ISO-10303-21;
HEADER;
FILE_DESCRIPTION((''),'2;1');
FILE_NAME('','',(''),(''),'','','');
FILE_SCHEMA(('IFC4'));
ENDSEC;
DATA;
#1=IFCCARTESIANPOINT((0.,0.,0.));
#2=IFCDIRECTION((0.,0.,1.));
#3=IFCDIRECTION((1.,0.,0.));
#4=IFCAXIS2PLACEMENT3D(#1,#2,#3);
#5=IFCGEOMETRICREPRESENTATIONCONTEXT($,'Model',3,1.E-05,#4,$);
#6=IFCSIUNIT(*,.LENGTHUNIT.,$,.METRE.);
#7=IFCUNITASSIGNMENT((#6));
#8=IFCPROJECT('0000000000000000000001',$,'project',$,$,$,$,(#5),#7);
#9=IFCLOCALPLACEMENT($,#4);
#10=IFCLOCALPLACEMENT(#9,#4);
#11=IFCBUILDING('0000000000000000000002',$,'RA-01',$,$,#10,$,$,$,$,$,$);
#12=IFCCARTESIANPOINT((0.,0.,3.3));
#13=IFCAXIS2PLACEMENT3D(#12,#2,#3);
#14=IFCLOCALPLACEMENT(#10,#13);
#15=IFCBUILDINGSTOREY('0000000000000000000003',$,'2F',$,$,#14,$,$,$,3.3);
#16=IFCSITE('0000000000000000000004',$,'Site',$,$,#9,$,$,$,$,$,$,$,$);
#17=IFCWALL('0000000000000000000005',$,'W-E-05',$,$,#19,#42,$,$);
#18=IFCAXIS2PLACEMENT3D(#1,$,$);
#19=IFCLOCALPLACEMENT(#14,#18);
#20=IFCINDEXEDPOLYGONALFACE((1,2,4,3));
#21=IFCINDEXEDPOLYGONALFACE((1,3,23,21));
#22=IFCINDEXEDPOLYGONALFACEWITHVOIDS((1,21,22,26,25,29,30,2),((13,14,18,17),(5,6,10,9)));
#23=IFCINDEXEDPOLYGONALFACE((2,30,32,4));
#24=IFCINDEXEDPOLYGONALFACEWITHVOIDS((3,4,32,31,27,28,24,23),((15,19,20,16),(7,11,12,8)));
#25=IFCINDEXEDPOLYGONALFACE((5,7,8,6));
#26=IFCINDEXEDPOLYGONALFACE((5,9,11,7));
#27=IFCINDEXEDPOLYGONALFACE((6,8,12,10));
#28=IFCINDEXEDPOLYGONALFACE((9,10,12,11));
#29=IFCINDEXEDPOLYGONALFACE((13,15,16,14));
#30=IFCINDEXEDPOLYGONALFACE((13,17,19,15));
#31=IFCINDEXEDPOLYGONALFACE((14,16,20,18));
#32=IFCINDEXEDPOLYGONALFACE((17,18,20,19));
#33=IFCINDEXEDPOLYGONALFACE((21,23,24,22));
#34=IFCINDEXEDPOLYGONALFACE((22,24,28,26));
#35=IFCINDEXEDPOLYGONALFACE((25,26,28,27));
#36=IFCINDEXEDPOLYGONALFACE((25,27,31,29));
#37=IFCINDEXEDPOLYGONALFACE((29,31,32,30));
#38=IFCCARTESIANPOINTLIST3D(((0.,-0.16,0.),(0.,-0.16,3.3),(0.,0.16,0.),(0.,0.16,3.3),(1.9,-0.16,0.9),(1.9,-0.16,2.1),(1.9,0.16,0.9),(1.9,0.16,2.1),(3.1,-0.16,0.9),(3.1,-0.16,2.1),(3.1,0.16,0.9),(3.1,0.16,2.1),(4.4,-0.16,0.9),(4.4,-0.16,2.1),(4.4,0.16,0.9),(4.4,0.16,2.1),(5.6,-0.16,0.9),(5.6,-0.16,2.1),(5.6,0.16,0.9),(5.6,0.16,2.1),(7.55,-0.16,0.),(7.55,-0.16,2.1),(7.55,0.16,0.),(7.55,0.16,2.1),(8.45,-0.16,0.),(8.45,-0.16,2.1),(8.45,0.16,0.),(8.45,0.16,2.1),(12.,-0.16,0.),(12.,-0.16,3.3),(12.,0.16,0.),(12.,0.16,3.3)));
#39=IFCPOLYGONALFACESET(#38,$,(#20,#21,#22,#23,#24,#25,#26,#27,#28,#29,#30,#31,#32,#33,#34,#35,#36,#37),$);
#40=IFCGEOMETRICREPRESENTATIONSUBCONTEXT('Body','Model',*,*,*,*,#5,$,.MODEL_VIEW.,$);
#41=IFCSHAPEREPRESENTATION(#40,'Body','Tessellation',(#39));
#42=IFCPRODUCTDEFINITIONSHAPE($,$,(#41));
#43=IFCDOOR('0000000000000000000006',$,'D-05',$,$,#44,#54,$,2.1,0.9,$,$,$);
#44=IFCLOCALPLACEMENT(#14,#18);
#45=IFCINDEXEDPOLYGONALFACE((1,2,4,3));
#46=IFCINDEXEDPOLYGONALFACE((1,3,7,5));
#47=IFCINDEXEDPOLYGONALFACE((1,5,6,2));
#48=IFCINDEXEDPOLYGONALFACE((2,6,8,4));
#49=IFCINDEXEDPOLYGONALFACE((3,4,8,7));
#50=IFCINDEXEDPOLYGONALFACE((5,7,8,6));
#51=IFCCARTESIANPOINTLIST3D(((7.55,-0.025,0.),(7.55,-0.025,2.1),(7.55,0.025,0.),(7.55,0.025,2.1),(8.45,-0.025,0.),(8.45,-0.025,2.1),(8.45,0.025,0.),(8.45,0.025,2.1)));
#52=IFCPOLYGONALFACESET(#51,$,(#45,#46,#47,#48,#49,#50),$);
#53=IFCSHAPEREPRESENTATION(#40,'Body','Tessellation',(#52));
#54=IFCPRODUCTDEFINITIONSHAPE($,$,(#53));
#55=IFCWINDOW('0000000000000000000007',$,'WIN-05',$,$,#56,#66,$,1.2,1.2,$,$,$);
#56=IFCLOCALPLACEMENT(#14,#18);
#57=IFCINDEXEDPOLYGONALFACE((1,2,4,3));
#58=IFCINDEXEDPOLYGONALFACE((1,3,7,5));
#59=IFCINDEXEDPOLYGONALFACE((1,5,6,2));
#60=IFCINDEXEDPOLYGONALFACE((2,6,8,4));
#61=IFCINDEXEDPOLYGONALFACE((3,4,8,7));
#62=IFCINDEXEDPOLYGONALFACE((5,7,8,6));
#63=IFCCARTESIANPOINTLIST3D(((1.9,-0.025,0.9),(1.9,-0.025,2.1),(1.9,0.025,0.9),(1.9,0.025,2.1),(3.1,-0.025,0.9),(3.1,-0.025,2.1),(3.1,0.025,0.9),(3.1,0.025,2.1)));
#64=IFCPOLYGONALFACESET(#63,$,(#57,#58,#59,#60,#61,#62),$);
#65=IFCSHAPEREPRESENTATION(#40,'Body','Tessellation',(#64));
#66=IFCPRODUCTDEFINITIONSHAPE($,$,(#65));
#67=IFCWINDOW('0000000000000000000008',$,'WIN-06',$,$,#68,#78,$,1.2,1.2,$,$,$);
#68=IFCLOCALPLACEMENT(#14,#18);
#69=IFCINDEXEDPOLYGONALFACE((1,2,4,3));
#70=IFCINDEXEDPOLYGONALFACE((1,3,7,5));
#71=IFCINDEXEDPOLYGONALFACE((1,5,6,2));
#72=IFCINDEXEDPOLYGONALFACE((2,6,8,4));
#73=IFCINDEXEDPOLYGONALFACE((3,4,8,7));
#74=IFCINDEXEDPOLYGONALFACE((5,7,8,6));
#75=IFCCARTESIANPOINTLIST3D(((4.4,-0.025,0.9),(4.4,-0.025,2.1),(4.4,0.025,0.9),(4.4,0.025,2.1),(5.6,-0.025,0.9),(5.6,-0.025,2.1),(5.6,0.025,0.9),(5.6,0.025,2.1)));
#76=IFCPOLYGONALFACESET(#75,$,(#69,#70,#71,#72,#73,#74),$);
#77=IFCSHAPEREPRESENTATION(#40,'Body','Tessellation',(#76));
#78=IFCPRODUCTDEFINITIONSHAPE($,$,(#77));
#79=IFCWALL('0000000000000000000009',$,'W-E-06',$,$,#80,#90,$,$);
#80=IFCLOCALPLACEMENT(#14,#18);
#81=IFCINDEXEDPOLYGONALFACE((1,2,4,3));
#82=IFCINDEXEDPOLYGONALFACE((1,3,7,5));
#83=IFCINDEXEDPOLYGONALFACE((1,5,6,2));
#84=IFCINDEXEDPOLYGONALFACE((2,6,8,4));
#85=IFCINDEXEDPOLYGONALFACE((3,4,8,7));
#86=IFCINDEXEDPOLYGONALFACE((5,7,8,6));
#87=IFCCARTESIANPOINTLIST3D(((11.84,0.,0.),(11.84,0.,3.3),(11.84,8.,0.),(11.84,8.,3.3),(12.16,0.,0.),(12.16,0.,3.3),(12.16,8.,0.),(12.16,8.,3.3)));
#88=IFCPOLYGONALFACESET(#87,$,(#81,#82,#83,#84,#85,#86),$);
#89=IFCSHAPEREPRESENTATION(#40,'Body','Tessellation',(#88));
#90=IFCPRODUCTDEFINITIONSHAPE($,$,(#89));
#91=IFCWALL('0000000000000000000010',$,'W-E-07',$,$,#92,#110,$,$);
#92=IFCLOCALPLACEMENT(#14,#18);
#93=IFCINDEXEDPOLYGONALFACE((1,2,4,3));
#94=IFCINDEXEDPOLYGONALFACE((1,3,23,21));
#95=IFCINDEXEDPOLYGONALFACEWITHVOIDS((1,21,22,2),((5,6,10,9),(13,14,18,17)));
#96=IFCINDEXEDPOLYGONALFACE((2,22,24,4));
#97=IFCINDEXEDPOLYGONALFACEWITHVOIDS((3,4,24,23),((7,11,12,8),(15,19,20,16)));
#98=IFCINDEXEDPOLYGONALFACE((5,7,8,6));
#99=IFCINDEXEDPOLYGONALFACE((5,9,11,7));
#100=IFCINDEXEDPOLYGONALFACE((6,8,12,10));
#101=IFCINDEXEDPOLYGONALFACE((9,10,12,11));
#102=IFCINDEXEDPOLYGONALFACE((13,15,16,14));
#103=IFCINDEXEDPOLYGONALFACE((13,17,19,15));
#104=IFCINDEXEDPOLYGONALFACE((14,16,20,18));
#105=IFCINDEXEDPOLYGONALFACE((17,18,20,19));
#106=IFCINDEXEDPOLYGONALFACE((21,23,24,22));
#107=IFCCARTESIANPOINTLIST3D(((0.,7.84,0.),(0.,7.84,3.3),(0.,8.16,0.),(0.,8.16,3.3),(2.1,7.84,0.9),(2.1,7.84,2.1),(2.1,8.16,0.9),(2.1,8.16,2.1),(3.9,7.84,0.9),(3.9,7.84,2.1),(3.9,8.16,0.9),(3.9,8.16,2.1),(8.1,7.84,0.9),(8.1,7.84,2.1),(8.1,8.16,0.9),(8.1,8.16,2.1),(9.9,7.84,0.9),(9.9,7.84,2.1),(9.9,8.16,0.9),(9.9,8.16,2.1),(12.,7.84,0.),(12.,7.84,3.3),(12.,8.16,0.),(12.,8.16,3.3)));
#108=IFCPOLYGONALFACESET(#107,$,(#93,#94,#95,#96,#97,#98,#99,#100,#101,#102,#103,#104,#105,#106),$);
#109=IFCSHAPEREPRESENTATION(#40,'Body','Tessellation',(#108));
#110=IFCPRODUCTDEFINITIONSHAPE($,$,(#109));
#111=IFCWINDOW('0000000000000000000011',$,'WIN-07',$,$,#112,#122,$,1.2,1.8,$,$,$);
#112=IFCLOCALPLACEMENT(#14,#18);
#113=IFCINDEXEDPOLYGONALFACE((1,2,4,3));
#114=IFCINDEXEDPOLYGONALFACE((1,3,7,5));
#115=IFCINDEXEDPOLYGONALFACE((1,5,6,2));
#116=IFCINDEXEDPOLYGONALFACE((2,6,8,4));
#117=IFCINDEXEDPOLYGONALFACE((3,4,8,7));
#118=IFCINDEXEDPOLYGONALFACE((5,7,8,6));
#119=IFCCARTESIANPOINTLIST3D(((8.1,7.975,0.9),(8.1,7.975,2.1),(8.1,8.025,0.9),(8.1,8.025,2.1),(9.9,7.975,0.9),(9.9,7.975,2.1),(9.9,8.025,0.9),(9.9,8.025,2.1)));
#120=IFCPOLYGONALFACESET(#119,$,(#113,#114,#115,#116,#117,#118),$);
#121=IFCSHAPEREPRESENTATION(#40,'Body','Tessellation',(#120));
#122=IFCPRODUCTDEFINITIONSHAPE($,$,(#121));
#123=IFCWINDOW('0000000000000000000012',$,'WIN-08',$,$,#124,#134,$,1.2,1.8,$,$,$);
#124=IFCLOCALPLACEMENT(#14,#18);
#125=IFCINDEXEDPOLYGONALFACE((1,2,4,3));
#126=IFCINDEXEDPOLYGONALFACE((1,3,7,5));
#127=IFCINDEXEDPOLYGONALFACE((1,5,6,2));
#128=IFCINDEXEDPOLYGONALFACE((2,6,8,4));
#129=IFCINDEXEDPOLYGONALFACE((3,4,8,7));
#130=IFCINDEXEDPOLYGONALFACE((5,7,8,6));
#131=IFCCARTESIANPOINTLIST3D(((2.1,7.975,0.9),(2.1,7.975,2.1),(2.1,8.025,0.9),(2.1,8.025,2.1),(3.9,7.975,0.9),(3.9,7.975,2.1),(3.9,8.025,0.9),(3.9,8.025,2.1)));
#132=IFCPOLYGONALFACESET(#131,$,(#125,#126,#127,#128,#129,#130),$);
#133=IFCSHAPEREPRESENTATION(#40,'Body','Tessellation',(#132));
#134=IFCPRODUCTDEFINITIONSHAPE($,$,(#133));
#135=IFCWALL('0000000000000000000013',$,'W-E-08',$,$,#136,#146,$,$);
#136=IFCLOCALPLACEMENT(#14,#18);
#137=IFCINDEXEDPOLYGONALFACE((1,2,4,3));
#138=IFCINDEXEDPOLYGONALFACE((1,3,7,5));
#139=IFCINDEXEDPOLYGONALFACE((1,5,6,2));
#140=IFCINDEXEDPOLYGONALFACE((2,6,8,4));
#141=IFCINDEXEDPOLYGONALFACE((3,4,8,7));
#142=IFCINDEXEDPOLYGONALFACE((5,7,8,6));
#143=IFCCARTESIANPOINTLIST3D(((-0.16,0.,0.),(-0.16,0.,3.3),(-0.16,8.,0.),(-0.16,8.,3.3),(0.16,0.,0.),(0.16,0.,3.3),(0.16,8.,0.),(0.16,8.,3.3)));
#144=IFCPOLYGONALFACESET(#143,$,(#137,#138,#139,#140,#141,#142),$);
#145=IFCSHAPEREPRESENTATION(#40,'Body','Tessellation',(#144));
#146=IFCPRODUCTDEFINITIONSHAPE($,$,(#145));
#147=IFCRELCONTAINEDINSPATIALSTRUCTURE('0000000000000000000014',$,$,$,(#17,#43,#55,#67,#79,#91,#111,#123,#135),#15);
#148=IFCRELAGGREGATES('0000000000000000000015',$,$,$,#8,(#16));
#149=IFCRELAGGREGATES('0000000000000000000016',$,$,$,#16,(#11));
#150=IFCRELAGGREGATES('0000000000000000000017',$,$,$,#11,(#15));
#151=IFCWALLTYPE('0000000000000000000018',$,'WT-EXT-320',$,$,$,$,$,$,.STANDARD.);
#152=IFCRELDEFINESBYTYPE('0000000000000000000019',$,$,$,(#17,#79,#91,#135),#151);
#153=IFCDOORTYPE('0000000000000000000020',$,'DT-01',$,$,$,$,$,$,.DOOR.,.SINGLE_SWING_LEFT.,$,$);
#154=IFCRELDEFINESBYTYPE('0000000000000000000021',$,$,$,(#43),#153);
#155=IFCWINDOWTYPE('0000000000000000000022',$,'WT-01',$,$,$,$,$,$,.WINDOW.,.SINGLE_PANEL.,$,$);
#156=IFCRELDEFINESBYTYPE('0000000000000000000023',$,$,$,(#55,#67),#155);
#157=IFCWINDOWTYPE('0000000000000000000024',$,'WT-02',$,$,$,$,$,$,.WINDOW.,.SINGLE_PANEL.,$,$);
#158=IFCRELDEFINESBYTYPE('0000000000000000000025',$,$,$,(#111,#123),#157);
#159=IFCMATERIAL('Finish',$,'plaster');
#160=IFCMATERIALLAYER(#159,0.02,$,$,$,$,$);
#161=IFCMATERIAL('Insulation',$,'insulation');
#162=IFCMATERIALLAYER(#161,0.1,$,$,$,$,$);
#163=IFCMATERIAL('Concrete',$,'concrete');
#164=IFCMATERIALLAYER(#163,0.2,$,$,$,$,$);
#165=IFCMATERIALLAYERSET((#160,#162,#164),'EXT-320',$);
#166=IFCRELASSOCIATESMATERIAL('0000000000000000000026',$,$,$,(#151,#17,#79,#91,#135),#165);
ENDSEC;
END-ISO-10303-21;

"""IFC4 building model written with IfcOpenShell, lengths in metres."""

from ifc_helpers import new_model, si_unit, frame, frame_2d, origin_with_axes, origin_2d_with_axis, place, context, subcontext, project, spatial, rectangle, extrude, material, layer, layer_set, layer_usage, type_object, element, fill, save


model = new_model("IFC4")

# Units and contexts
model_context = context("Model", 3, precision=1e-05, world=origin_with_axes())
body_context = subcontext(model_context, "Body", "Model", "MODEL_VIEW")
ifc_project = project(units=[si_unit("LENGTHUNIT", "METRE")], contexts=[model_context])

# Site, building, storey
site_placement = place(None, origin_with_axes())
site = spatial("IfcSite", under=ifc_project, at=site_placement, Name="Site")
building_placement = place(site_placement, origin_with_axes())
building = spatial("IfcBuilding", under=site, at=building_placement, Name="RA-01")
storey_placement = place(building_placement, frame((0.0, 0.0, 3.3), z_axis=(0.0, 0.0, 1.0), x_axis=(1.0, 0.0, 0.0)))
storey = spatial("IfcBuildingStorey", under=building, at=storey_placement, Name="2F", Elevation=3.3)

# Shared definitions
ifc_material_1 = material(Name="Concrete", Category="concrete")

# Wall, openings, door, windows
ifc_material_2 = material(Name="Finish", Category="plaster")
ifc_layer_1 = layer(ifc_material_2, 0.02)
ifc_material_3 = material(Name="Insulation", Category="insulation")
ifc_layer_2 = layer(ifc_material_3, 0.1)
ifc_layer_3 = layer(ifc_material_1, 0.2)
ifc_layer_set_1 = layer_set([ifc_layer_1, ifc_layer_2, ifc_layer_3], Name="EXT-320")
ifc_layer_usage_1 = layer_usage(ifc_layer_set_1, "AXIS2", "POSITIVE", -0.16)
wall_type_1 = type_object("IfcWallType", Name="WT-EXT-320", PredefinedType="STANDARD", material=ifc_layer_set_1)
wall_1_placement = place(storey_placement, origin_with_axes())
wall_1 = element("IfcWall", 1, at=wall_1_placement, inside=storey, type_object=wall_type_1, material=ifc_layer_usage_1, Name="W-E-05", context=body_context, shape_type="SweptSolid", body=[
    extrude(rectangle(XDim=12.0, YDim=0.32, at=frame_2d((6.0, 0.0), x_axis=(1.0, 0.0))), origin_with_axes(), (0.0, 0.0, 1.0), 3.3),
])
opening_1_placement = place(wall_1_placement, frame((8.0, 0.0, 0.0), z_axis=(0.0, 0.0, 1.0), x_axis=(1.0, 0.0, 0.0)))
opening_1 = element("IfcOpeningElement", 2, at=opening_1_placement, cuts=wall_1, PredefinedType="OPENING", context=body_context, shape_type="SweptSolid", body=[
    extrude(rectangle(XDim=0.9, YDim=0.42, at=origin_2d_with_axis()), origin_with_axes(), (0.0, 0.0, 1.0), 2.1),
])
opening_2_placement = place(wall_1_placement, frame((2.5, 0.0, 0.9), z_axis=(0.0, 0.0, 1.0), x_axis=(1.0, 0.0, 0.0)))
opening_2 = element("IfcOpeningElement", 3, at=opening_2_placement, cuts=wall_1, PredefinedType="OPENING", context=body_context, shape_type="SweptSolid", body=[
    extrude(rectangle(XDim=1.2, YDim=0.42, at=origin_2d_with_axis()), origin_with_axes(), (0.0, 0.0, 1.0), 1.2),
])
opening_3_placement = place(wall_1_placement, frame((5.0, 0.0, 0.9), z_axis=(0.0, 0.0, 1.0), x_axis=(1.0, 0.0, 0.0)))
opening_3 = element("IfcOpeningElement", 4, at=opening_3_placement, cuts=wall_1, PredefinedType="OPENING", context=body_context, shape_type="SweptSolid", body=[
    extrude(rectangle(XDim=1.2, YDim=0.42, at=origin_2d_with_axis()), origin_with_axes(), (0.0, 0.0, 1.0), 1.2),
])
door_type_1 = type_object("IfcDoorType", Name="DT-01", OperationType="SINGLE_SWING_LEFT", PredefinedType="DOOR")
door_1_placement = place(opening_1_placement, origin_with_axes())
door_1 = element("IfcDoor", 5, at=door_1_placement, inside=storey, type_object=door_type_1, Name="D-05", OverallHeight=2.1, OverallWidth=0.9, context=body_context, shape_type="SweptSolid", body=[
    extrude(rectangle(XDim=0.9, YDim=0.05, at=origin_2d_with_axis()), origin_with_axes(), (0.0, 0.0, 1.0), 2.1),
])
fill(opening_1, door_1)
window_type_1 = type_object("IfcWindowType", Name="WT-01", PartitioningType="SINGLE_PANEL", PredefinedType="WINDOW")
window_1_placement = place(opening_2_placement, origin_with_axes())
window_1 = element("IfcWindow", 6, at=window_1_placement, inside=storey, type_object=window_type_1, Name="WIN-05", OverallHeight=1.2, OverallWidth=1.2, context=body_context, shape_type="SweptSolid", body=[
    extrude(rectangle(XDim=1.2, YDim=0.05, at=origin_2d_with_axis()), origin_with_axes(), (0.0, 0.0, 1.0), 1.2),
])
fill(opening_2, window_1)
window_2_placement = place(opening_3_placement, origin_with_axes())
window_2 = element("IfcWindow", 7, at=window_2_placement, inside=storey, type_object=window_type_1, Name="WIN-06", OverallHeight=1.2, OverallWidth=1.2, context=body_context, shape_type="SweptSolid", body=[
    extrude(rectangle(XDim=1.2, YDim=0.05, at=origin_2d_with_axis()), origin_with_axes(), (0.0, 0.0, 1.0), 1.2),
])
fill(opening_3, window_2)

# Wall
ifc_layer_usage_2 = layer_usage(ifc_layer_set_1, "AXIS2", "POSITIVE", -0.16)
wall_2_placement = place(storey_placement, frame((12.0, 0.0, 0.0), z_axis=(0.0, 0.0, 1.0), x_axis=(0.0, 1.0, 0.0)))
element("IfcWall", 8, at=wall_2_placement, inside=storey, type_object=wall_type_1, material=ifc_layer_usage_2, Name="W-E-06", context=body_context, shape_type="SweptSolid", body=[
    extrude(rectangle(XDim=8.0, YDim=0.32, at=frame_2d((4.0, 0.0), x_axis=(1.0, 0.0))), origin_with_axes(), (0.0, 0.0, 1.0), 3.3),
])

# Wall, openings, windows
ifc_layer_usage_3 = layer_usage(ifc_layer_set_1, "AXIS2", "POSITIVE", -0.16)
wall_3_placement = place(storey_placement, frame((12.0, 8.0, 0.0), z_axis=(0.0, 0.0, 1.0), x_axis=(-1.0, 0.0, 0.0)))
wall_3 = element("IfcWall", 9, at=wall_3_placement, inside=storey, type_object=wall_type_1, material=ifc_layer_usage_3, Name="W-E-07", context=body_context, shape_type="SweptSolid", body=[
    extrude(rectangle(XDim=12.0, YDim=0.32, at=frame_2d((6.0, 0.0), x_axis=(1.0, 0.0))), origin_with_axes(), (0.0, 0.0, 1.0), 3.3),
])
opening_4_placement = place(wall_3_placement, frame((3.0, 0.0, 0.9), z_axis=(0.0, 0.0, 1.0), x_axis=(1.0, 0.0, 0.0)))
opening_4 = element("IfcOpeningElement", 10, at=opening_4_placement, cuts=wall_3, PredefinedType="OPENING", context=body_context, shape_type="SweptSolid", body=[
    extrude(rectangle(XDim=1.8, YDim=0.42, at=origin_2d_with_axis()), origin_with_axes(), (0.0, 0.0, 1.0), 1.2),
])
opening_5_placement = place(wall_3_placement, frame((9.0, 0.0, 0.9), z_axis=(0.0, 0.0, 1.0), x_axis=(1.0, 0.0, 0.0)))
opening_5 = element("IfcOpeningElement", 11, at=opening_5_placement, cuts=wall_3, PredefinedType="OPENING", context=body_context, shape_type="SweptSolid", body=[
    extrude(rectangle(XDim=1.8, YDim=0.42, at=origin_2d_with_axis()), origin_with_axes(), (0.0, 0.0, 1.0), 1.2),
])
window_type_2 = type_object("IfcWindowType", Name="WT-02", PartitioningType="SINGLE_PANEL", PredefinedType="WINDOW")
window_3_placement = place(opening_4_placement, origin_with_axes())
window_3 = element("IfcWindow", 12, at=window_3_placement, inside=storey, type_object=window_type_2, Name="WIN-07", OverallHeight=1.2, OverallWidth=1.8, context=body_context, shape_type="SweptSolid", body=[
    extrude(rectangle(XDim=1.8, YDim=0.05, at=origin_2d_with_axis()), origin_with_axes(), (0.0, 0.0, 1.0), 1.2),
])
fill(opening_4, window_3)
window_4_placement = place(opening_5_placement, origin_with_axes())
window_4 = element("IfcWindow", 13, at=window_4_placement, inside=storey, type_object=window_type_2, Name="WIN-08", OverallHeight=1.2, OverallWidth=1.8, context=body_context, shape_type="SweptSolid", body=[
    extrude(rectangle(XDim=1.8, YDim=0.05, at=origin_2d_with_axis()), origin_with_axes(), (0.0, 0.0, 1.0), 1.2),
])
fill(opening_5, window_4)

# Wall
ifc_layer_usage_4 = layer_usage(ifc_layer_set_1, "AXIS2", "POSITIVE", -0.16)
wall_4_placement = place(storey_placement, frame((0.0, 8.0, 0.0), z_axis=(0.0, 0.0, 1.0), x_axis=(0.0, -1.0, 0.0)))
element("IfcWall", 14, at=wall_4_placement, inside=storey, type_object=wall_type_1, material=ifc_layer_usage_4, Name="W-E-08", context=body_context, shape_type="SweptSolid", body=[
    extrude(rectangle(XDim=8.0, YDim=0.32, at=frame_2d((4.0, 0.0), x_axis=(1.0, 0.0))), origin_with_axes(), (0.0, 0.0, 1.0), 3.3),
])

save(model, "model.ifc")
